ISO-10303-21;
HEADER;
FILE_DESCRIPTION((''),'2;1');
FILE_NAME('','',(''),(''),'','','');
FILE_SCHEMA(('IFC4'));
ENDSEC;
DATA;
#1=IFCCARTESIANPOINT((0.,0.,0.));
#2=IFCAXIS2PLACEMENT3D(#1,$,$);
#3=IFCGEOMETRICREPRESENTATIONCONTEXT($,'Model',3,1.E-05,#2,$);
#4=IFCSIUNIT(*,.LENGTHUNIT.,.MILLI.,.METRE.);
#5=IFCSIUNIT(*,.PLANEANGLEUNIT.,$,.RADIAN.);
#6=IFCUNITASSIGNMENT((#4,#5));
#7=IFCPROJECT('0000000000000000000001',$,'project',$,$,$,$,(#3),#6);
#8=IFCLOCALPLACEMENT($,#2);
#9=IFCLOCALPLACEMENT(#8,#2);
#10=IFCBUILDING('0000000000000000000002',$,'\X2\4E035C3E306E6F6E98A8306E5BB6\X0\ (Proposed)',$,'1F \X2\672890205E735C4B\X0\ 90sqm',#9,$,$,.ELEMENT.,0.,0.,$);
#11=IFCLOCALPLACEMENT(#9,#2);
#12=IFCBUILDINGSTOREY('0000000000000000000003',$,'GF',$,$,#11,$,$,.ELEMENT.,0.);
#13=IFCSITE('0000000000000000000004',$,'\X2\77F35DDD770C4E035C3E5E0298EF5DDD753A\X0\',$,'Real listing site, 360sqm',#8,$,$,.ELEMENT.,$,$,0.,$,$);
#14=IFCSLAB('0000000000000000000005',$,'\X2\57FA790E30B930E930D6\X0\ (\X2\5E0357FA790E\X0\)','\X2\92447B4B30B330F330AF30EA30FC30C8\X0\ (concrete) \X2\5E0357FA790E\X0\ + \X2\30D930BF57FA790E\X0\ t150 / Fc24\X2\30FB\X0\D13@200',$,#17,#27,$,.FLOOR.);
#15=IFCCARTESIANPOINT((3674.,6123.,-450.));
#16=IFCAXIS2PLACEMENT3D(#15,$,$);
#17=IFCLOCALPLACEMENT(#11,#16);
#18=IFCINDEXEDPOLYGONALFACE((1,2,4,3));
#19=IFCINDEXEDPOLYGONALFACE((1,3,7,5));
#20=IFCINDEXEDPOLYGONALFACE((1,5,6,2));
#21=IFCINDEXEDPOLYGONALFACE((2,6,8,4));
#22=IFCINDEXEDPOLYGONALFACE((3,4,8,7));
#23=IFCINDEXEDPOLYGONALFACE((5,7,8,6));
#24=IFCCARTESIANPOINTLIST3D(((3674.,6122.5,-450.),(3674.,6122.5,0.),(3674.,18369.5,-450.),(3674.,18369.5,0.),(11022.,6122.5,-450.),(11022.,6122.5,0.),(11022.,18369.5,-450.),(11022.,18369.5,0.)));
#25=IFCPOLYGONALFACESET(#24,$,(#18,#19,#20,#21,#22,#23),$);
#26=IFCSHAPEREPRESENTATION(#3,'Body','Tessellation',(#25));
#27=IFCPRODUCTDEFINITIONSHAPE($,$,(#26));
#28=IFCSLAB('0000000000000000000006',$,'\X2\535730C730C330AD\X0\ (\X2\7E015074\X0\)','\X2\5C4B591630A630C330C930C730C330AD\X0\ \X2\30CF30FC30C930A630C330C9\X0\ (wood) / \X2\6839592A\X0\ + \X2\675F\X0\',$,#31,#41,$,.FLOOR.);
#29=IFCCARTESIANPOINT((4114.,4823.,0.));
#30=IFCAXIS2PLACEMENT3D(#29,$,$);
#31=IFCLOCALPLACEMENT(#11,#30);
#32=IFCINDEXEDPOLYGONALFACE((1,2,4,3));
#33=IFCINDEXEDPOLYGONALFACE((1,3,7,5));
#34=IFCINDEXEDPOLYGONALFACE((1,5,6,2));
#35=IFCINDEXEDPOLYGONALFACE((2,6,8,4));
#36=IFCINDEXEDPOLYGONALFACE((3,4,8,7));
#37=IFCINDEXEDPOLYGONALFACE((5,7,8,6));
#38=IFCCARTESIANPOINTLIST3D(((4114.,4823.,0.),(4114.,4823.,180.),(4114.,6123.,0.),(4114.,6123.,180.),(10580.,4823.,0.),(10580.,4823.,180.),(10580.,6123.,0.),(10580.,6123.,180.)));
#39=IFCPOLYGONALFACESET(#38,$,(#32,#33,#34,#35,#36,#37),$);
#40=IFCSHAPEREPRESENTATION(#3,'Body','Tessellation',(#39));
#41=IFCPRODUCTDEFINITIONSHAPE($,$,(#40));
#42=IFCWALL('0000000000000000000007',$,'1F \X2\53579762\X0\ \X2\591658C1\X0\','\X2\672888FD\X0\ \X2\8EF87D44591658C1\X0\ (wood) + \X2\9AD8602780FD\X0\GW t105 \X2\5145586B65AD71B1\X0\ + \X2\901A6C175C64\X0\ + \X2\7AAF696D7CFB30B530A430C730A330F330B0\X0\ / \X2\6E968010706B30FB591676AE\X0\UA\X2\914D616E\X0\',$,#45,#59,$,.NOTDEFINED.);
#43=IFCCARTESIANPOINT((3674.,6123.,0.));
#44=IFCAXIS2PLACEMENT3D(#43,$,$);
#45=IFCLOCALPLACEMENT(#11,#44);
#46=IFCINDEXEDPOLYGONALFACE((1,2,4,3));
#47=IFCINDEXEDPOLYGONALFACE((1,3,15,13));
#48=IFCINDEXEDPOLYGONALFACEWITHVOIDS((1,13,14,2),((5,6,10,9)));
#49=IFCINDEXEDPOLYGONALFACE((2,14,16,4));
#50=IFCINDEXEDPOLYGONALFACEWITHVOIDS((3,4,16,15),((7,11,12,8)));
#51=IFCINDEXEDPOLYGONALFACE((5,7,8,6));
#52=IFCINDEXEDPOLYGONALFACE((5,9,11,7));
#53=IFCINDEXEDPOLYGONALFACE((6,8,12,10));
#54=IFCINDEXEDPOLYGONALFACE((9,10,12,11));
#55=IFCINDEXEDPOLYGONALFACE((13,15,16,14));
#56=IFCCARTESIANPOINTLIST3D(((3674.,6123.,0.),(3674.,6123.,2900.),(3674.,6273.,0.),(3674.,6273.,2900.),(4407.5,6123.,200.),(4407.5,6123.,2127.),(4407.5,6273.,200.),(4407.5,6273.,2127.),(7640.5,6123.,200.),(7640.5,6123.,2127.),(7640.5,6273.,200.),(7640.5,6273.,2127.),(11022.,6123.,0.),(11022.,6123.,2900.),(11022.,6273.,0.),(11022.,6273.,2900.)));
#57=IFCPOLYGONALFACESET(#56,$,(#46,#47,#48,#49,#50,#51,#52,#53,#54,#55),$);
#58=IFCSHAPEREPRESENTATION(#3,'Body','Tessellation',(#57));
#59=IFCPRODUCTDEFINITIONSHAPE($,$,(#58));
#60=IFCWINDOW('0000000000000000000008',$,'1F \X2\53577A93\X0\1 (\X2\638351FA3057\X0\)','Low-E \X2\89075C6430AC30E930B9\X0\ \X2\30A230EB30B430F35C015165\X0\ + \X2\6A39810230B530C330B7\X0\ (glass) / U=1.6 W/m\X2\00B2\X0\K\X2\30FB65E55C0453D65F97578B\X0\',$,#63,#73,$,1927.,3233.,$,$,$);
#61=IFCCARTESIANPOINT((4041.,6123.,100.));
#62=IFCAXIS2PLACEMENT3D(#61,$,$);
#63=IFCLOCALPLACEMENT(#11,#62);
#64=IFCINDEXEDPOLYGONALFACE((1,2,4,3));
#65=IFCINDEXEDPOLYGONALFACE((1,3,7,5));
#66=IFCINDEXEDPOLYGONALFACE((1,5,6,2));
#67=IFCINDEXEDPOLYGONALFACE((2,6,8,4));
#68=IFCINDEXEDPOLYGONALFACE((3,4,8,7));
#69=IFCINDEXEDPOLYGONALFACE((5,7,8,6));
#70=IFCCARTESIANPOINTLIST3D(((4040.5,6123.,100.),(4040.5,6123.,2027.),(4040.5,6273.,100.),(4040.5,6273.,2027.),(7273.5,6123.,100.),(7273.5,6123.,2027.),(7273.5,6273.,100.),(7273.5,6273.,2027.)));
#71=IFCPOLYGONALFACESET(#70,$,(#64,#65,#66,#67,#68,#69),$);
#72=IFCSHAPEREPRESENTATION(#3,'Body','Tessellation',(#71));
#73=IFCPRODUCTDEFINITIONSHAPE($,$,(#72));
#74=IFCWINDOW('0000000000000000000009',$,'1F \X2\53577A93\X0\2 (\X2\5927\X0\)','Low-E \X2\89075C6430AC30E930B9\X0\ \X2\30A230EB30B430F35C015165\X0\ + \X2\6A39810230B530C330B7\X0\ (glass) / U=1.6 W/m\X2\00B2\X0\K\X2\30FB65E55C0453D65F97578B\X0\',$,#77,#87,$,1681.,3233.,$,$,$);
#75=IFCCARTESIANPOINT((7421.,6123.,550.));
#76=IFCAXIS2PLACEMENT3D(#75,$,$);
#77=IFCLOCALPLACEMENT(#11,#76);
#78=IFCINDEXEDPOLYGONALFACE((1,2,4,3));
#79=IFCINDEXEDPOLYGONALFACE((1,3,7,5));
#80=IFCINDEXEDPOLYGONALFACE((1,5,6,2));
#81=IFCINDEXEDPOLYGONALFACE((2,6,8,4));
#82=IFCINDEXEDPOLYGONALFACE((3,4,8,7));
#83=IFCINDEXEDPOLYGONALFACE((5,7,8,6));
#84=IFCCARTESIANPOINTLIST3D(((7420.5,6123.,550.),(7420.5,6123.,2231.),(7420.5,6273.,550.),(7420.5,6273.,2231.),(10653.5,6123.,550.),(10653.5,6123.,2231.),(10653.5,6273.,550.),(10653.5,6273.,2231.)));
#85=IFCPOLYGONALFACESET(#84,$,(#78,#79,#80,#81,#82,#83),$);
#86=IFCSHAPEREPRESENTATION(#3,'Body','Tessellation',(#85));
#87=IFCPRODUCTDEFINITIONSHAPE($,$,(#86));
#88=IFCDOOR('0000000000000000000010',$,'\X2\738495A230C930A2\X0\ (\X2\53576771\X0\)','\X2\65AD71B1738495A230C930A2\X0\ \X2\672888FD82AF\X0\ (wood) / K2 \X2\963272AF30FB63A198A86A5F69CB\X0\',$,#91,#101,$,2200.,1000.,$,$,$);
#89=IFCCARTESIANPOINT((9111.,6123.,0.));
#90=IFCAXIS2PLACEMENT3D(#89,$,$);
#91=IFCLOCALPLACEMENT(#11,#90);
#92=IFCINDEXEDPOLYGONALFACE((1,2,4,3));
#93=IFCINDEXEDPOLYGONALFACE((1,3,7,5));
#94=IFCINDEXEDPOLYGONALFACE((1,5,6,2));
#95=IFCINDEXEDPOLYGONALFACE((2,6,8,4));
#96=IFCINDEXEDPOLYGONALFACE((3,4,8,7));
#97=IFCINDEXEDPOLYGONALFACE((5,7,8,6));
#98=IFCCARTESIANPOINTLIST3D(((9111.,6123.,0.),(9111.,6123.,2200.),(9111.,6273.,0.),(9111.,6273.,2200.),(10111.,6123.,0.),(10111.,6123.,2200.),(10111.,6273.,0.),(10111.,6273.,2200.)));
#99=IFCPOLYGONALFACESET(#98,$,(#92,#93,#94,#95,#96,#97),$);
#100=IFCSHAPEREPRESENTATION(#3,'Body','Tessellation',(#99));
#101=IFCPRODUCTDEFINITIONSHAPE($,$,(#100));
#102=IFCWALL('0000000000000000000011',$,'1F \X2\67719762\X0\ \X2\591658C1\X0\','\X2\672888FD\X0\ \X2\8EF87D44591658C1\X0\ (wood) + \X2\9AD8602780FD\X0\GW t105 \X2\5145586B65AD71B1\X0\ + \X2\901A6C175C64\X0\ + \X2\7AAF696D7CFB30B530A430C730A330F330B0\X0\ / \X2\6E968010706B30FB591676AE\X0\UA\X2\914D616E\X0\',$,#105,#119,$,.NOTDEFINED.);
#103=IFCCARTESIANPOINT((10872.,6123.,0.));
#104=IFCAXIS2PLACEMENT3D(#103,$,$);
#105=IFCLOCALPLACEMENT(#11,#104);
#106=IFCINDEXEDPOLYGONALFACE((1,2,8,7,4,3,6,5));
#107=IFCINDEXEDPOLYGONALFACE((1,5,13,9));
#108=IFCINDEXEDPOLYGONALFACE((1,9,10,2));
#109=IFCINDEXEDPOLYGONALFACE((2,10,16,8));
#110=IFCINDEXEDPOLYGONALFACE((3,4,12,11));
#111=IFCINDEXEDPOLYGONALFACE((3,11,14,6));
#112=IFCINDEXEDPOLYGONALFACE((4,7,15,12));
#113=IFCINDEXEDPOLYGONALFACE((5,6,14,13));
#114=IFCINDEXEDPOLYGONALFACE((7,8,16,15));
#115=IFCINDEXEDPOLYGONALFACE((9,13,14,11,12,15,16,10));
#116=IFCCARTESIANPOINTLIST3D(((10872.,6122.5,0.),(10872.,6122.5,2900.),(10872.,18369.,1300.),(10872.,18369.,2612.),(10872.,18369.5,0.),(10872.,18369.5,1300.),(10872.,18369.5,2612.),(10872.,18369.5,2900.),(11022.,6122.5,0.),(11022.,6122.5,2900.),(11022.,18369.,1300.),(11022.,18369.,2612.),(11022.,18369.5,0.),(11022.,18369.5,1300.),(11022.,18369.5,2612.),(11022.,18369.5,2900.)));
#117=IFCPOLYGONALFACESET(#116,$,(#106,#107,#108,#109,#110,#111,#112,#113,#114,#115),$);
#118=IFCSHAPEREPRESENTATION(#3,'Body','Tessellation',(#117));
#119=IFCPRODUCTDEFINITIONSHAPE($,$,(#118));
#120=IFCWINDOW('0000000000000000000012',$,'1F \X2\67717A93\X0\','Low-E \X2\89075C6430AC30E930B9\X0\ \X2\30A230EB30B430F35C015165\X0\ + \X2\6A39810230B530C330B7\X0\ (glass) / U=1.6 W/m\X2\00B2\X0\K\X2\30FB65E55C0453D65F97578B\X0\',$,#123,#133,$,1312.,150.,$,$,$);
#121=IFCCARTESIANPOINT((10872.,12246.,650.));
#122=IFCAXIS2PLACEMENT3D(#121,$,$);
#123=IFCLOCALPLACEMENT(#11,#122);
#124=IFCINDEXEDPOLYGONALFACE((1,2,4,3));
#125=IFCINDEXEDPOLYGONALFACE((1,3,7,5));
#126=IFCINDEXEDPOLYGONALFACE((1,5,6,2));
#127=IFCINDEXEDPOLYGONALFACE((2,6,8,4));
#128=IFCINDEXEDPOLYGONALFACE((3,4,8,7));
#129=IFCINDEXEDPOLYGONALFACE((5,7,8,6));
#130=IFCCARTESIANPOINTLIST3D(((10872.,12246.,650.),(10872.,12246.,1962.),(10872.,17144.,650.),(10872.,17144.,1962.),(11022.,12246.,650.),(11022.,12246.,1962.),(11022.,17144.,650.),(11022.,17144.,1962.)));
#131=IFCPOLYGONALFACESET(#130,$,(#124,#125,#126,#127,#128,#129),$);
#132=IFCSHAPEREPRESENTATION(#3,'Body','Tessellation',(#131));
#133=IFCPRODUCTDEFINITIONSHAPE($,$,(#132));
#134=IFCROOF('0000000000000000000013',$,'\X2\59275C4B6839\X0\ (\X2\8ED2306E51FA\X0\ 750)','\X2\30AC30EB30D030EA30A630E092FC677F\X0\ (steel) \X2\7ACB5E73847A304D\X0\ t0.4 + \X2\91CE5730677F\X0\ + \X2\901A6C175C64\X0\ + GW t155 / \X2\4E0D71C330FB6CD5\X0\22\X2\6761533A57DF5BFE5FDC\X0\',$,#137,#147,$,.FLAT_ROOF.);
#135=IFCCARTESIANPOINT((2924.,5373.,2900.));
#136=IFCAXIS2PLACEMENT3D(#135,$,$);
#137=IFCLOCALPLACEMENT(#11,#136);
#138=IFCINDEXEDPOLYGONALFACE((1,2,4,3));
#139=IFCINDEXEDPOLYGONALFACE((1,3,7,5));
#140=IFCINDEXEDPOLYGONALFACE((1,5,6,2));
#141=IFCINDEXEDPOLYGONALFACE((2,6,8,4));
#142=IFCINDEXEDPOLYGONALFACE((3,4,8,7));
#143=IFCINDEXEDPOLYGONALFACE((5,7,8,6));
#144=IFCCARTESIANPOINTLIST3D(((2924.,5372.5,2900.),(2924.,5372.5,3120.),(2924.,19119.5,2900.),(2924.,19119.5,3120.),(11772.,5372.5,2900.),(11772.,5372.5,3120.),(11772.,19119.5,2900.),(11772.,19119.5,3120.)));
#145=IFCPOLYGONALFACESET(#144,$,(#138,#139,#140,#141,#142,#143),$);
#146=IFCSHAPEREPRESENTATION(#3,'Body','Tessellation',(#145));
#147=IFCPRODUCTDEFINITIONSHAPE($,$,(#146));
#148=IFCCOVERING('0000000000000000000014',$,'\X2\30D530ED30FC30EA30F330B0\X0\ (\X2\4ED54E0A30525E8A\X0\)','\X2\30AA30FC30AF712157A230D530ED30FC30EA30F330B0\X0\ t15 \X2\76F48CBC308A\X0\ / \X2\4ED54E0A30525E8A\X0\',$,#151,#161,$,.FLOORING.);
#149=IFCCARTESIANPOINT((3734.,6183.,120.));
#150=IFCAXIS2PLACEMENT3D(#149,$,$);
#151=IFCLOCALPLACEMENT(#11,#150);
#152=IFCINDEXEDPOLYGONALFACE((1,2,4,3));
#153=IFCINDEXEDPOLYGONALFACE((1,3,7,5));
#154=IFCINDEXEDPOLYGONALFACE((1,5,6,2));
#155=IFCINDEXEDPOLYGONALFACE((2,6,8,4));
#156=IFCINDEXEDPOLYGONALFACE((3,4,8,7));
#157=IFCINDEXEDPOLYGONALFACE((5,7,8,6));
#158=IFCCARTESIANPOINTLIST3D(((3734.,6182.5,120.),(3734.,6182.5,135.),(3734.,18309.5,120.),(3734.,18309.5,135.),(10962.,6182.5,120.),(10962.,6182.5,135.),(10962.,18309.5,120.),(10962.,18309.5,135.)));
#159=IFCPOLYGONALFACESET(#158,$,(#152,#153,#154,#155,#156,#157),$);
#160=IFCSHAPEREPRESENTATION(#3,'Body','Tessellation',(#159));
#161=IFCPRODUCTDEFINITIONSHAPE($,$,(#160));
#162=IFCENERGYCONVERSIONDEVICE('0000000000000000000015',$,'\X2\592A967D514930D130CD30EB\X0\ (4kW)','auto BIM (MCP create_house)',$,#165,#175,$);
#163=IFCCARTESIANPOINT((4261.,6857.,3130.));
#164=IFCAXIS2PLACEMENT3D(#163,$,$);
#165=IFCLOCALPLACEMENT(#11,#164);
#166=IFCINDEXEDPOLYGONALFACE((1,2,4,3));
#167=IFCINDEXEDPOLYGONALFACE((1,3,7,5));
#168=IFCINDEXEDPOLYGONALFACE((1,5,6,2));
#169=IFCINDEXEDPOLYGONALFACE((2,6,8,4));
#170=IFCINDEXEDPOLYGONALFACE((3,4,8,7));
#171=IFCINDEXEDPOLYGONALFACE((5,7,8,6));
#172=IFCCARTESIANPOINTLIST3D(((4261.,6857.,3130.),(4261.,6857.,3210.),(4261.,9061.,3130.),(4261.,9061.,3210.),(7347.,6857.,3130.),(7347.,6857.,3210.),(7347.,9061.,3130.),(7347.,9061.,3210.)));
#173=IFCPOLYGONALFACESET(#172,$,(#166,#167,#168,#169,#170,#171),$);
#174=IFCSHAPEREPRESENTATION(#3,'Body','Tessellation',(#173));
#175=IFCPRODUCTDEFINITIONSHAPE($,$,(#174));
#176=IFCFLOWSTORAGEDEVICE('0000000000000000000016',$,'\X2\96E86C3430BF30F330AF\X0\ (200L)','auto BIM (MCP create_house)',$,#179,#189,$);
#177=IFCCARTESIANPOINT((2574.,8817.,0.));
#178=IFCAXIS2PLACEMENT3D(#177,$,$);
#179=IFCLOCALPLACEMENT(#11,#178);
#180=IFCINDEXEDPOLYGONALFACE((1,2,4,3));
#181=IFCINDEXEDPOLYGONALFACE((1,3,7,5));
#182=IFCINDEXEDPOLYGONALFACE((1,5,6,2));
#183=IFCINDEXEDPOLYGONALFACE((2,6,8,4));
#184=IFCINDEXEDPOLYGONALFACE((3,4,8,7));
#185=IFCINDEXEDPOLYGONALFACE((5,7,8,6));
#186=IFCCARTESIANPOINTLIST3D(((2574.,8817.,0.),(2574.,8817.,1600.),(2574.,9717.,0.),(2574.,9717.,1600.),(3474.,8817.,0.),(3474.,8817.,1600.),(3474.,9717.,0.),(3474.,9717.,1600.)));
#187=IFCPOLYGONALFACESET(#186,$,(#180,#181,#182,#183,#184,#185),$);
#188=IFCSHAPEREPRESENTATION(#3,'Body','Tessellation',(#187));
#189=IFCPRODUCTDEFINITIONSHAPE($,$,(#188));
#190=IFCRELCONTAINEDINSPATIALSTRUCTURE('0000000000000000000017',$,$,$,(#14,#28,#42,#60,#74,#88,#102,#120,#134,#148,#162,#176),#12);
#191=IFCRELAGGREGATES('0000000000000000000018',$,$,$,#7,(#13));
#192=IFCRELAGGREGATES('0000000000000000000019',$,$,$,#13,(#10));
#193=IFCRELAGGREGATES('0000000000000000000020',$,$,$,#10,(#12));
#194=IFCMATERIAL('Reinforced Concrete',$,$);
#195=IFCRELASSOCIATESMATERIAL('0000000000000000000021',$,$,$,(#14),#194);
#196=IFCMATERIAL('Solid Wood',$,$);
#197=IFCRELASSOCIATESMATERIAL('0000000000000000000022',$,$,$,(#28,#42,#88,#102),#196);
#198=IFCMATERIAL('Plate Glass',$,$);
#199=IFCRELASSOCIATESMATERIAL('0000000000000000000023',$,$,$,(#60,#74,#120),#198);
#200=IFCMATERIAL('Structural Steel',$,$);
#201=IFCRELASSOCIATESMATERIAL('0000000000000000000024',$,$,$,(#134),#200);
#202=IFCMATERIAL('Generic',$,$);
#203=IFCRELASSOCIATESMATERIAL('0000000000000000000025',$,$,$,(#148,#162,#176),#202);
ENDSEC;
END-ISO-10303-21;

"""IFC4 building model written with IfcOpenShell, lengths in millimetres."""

from ifc_helpers import new_model, si_unit, frame, frame_2d, origin, place, context, project, spatial, rectangle, extrude, material, element, fill, save


model = new_model("IFC4")

# Units and contexts
model_context = context("Model", 3, precision=1e-05, world=origin())
ifc_project = project(units=[si_unit("LENGTHUNIT", "METRE", prefix="MILLI"), si_unit("PLANEANGLEUNIT", "RADIAN")], contexts=[model_context])

# Site, building, storey
site_placement = place(None, origin())
site = spatial("IfcSite", under=ifc_project, at=site_placement, Name="石川県七尾市飯川町", ObjectType="Real listing site, 360sqm", CompositionType="ELEMENT", RefElevation=0.0)
building_placement = place(site_placement, origin())
building = spatial("IfcBuilding", under=site, at=building_placement, Name="七尾の潮風の家 (Proposed)", ObjectType="1F 木造平屋 90sqm", CompositionType="ELEMENT", ElevationOfRefHeight=0.0, ElevationOfTerrain=0.0)
storey_placement = place(building_placement, origin())
storey = spatial("IfcBuildingStorey", under=building, at=storey_placement, Name="GF", CompositionType="ELEMENT", Elevation=0.0)

# Slabs
ifc_material_1 = material(Name="Reinforced Concrete")
slab_1_placement = place(storey_placement, frame((3674.0, 6123.0, -450.0)))
element("IfcSlab", 1, at=slab_1_placement, inside=storey, material=ifc_material_1, Name="基礎スラブ (布基礎)", Description="鉄筋コンクリート (concrete) 布基礎 + ベタ基礎 t150 / Fc24・D13@200", PredefinedType="FLOOR", context=model_context, shape_type="SweptSolid", body=[
    extrude(rectangle(XDim=7348.0, YDim=12247.0, at=frame_2d((3674.0, 6123.0))), frame((3674.0, 6123.0, -450.0)), (0.0, 0.0, 1.0), 450.0),
])
ifc_material_2 = material(Name="Solid Wood")
slab_2_placement = place(storey_placement, frame((4114.0, 4823.0, 0.0)))
element("IfcSlab", 2, at=slab_2_placement, inside=storey, material=ifc_material_2, Name="南デッキ (縁側)", Description="屋外ウッドデッキ ハードウッド (wood) / 根太 + 束", PredefinedType="FLOOR", context=model_context, shape_type="SweptSolid", body=[
    extrude(rectangle(XDim=6466.0, YDim=1300.0, at=frame_2d((3233.0, 650.0))), frame((4114.0, 4823.0, 0.0)), (0.0, 0.0, 1.0), 180.0),
])

# Wall, openings, windows, door
wall_1_placement = place(storey_placement, frame((3674.0, 6123.0, 0.0)))
wall_1 = element("IfcWall", 3, at=wall_1_placement, inside=storey, material=ifc_material_2, Name="1F 南面 外壁", Description="木製 軸組外壁 (wood) + 高性能GW t105 充填断熱 + 通気層 + 窯業系サイディング / 準耐火・外皮UA配慮", PredefinedType="NOTDEFINED", context=model_context, shape_type="SweptSolid", body=[
    extrude(rectangle(XDim=7348.0, YDim=150.0, at=frame_2d((3674.0, 75.0))), frame((3674.0, 6123.0, 0.0)), (0.0, 0.0, 1.0), 2900.0),
])
opening_1_placement = place(storey_placement, frame((4041.0, 6123.0, 100.0)))
opening_1 = element("IfcOpeningElement", 4, at=opening_1_placement, cuts=wall_1, PredefinedType="NOTDEFINED", context=model_context, shape_type="SweptSolid", body=[
    extrude(rectangle(XDim=3233.0, YDim=150.0, at=frame_2d((1616.0, 75.0))), frame((4041.0, 6123.0, 100.0)), (0.0, 0.0, 1.0), 1927.0),
])
opening_2_placement = place(storey_placement, frame((7421.0, 6123.0, 550.0)))
opening_2 = element("IfcOpeningElement", 5, at=opening_2_placement, cuts=wall_1, PredefinedType="NOTDEFINED", context=model_context, shape_type="SweptSolid", body=[
    extrude(rectangle(XDim=3233.0, YDim=150.0, at=frame_2d((1616.0, 75.0))), frame((7421.0, 6123.0, 550.0)), (0.0, 0.0, 1.0), 1681.0),
])
opening_3_placement = place(storey_placement, frame((9111.0, 6123.0, 0.0)))
opening_3 = element("IfcOpeningElement", 6, at=opening_3_placement, cuts=wall_1, PredefinedType="NOTDEFINED", context=model_context, shape_type="SweptSolid", body=[
    extrude(rectangle(XDim=1000.0, YDim=150.0, at=frame_2d((500.0, 75.0))), frame((9111.0, 6123.0, 0.0)), (0.0, 0.0, 1.0), 2200.0),
])
ifc_material_3 = material(Name="Plate Glass")
window_1_placement = place(storey_placement, frame((4041.0, 6123.0, 100.0)))
window_1 = element("IfcWindow", 7, at=window_1_placement, inside=storey, material=ifc_material_3, Name="1F 南窓1 (掃出し)", Description="Low-E 複層ガラス アルゴン封入 + 樹脂サッシ (glass) / U=1.6 W/m²K・日射取得型", OverallHeight=1927.0, OverallWidth=3233.0, context=model_context, shape_type="SweptSolid", body=[
    extrude(rectangle(XDim=3233.0, YDim=150.0, at=frame_2d((1616.0, 75.0))), frame((4041.0, 6123.0, 100.0)), (0.0, 0.0, 1.0), 1927.0),
])
fill(opening_1, window_1)
window_2_placement = place(storey_placement, frame((7421.0, 6123.0, 550.0)))
window_2 = element("IfcWindow", 8, at=window_2_placement, inside=storey, material=ifc_material_3, Name="1F 南窓2 (大)", Description="Low-E 複層ガラス アルゴン封入 + 樹脂サッシ (glass) / U=1.6 W/m²K・日射取得型", OverallHeight=1681.0, OverallWidth=3233.0, context=model_context, shape_type="SweptSolid", body=[
    extrude(rectangle(XDim=3233.0, YDim=150.0, at=frame_2d((1616.0, 75.0))), frame((7421.0, 6123.0, 550.0)), (0.0, 0.0, 1.0), 1681.0),
])
fill(opening_2, window_2)
door_placement = place(storey_placement, frame((9111.0, 6123.0, 0.0)))
door = element("IfcDoor", 9, at=door_placement, inside=storey, material=ifc_material_2, Name="玄関ドア (南東)", Description="断熱玄関ドア 木製芯 (wood) / K2 防犯・採風機構", OverallHeight=2200.0, OverallWidth=1000.0, context=model_context, shape_type="SweptSolid", body=[
    extrude(rectangle(XDim=1000.0, YDim=150.0, at=frame_2d((500.0, 75.0))), frame((9111.0, 6123.0, 0.0)), (0.0, 0.0, 1.0), 2200.0),
])
fill(opening_3, door)

# Wall, opening, window
wall_2_placement = place(storey_placement, frame((10872.0, 6123.0, 0.0)))
wall_2 = element("IfcWall", 10, at=wall_2_placement, inside=storey, material=ifc_material_2, Name="1F 東面 外壁", Description="木製 軸組外壁 (wood) + 高性能GW t105 充填断熱 + 通気層 + 窯業系サイディング / 準耐火・外皮UA配慮", PredefinedType="NOTDEFINED", context=model_context, shape_type="SweptSolid", body=[
    extrude(rectangle(XDim=150.0, YDim=12247.0, at=frame_2d((75.0, 6123.0))), frame((10872.0, 6123.0, 0.0)), (0.0, 0.0, 1.0), 2900.0),
])
opening_4_placement = place(storey_placement, frame((10872.0, 12246.0, 650.0)))
opening_4 = element("IfcOpeningElement", 11, at=opening_4_placement, cuts=wall_2, PredefinedType="NOTDEFINED", context=model_context, shape_type="SweptSolid", body=[
    extrude(rectangle(XDim=150.0, YDim=4898.0, at=frame_2d((75.0, 2449.0))), frame((10872.0, 12246.0, 650.0)), (0.0, 0.0, 1.0), 1312.0),
])
window_3_placement = place(storey_placement, frame((10872.0, 12246.0, 650.0)))
window_3 = element("IfcWindow", 12, at=window_3_placement, inside=storey, material=ifc_material_3, Name="1F 東窓", Description="Low-E 複層ガラス アルゴン封入 + 樹脂サッシ (glass) / U=1.6 W/m²K・日射取得型", OverallHeight=1312.0, OverallWidth=150.0, context=model_context, shape_type="SweptSolid", body=[
    extrude(rectangle(XDim=150.0, YDim=4898.0, at=frame_2d((75.0, 2449.0))), frame((10872.0, 12246.0, 650.0)), (0.0, 0.0, 1.0), 1312.0),
])
fill(opening_4, window_3)

# Roof
ifc_material_4 = material(Name="Structural Steel")
roof_placement = place(storey_placement, frame((2924.0, 5373.0, 2900.0)))
element("IfcRoof", 13, at=roof_placement, inside=storey, material=ifc_material_4, Name="大屋根 (軒の出 750)", Description="ガルバリウム鋼板 (steel) 立平葺き t0.4 + 野地板 + 通気層 + GW t155 / 不燃・法22条区域対応", PredefinedType="FLAT_ROOF", context=model_context, shape_type="SweptSolid", body=[
    extrude(rectangle(XDim=8848.0, YDim=13747.0, at=frame_2d((4424.0, 6873.0))), frame((2924.0, 5373.0, 2900.0)), (0.0, 0.0, 1.0), 220.0),
])

# Covering
ifc_material_5 = material(Name="Generic")
covering_placement = place(storey_placement, frame((3734.0, 6183.0, 120.0)))
element("IfcCovering", 14, at=covering_placement, inside=storey, material=ifc_material_5, Name="フローリング (仕上げ床)", Description="オーク無垢フローリング t15 直貼り / 仕上げ床", PredefinedType="FLOORING", context=model_context, shape_type="SweptSolid", body=[
    extrude(rectangle(XDim=7228.0, YDim=12127.0, at=frame_2d((3614.0, 6063.0))), frame((3734.0, 6183.0, 120.0)), (0.0, 0.0, 1.0), 15.0),
])

# Energy conversion device
energy_conversion_device_placement = place(storey_placement, frame((4261.0, 6857.0, 3130.0)))
element("IfcEnergyConversionDevice", 15, at=energy_conversion_device_placement, inside=storey, material=ifc_material_5, Name="太陽光パネル (4kW)", Description="auto BIM (MCP create_house)", context=model_context, shape_type="SweptSolid", body=[
    extrude(rectangle(XDim=3086.0, YDim=2204.0, at=frame_2d((1543.0, 1102.0))), frame((4261.0, 6857.0, 3130.0)), (0.0, 0.0, 1.0), 80.0),
])

# Flow storage device
flow_storage_device_placement = place(storey_placement, frame((2574.0, 8817.0, 0.0)))
element("IfcFlowStorageDevice", 16, at=flow_storage_device_placement, inside=storey, material=ifc_material_5, Name="雨水タンク (200L)", Description="auto BIM (MCP create_house)", context=model_context, shape_type="SweptSolid", body=[
    extrude(rectangle(XDim=900.0, YDim=900.0, at=frame_2d((450.0, 450.0))), frame((2574.0, 8817.0, 0.0)), (0.0, 0.0, 1.0), 1600.0),
])

save(model, "model.ifc")
